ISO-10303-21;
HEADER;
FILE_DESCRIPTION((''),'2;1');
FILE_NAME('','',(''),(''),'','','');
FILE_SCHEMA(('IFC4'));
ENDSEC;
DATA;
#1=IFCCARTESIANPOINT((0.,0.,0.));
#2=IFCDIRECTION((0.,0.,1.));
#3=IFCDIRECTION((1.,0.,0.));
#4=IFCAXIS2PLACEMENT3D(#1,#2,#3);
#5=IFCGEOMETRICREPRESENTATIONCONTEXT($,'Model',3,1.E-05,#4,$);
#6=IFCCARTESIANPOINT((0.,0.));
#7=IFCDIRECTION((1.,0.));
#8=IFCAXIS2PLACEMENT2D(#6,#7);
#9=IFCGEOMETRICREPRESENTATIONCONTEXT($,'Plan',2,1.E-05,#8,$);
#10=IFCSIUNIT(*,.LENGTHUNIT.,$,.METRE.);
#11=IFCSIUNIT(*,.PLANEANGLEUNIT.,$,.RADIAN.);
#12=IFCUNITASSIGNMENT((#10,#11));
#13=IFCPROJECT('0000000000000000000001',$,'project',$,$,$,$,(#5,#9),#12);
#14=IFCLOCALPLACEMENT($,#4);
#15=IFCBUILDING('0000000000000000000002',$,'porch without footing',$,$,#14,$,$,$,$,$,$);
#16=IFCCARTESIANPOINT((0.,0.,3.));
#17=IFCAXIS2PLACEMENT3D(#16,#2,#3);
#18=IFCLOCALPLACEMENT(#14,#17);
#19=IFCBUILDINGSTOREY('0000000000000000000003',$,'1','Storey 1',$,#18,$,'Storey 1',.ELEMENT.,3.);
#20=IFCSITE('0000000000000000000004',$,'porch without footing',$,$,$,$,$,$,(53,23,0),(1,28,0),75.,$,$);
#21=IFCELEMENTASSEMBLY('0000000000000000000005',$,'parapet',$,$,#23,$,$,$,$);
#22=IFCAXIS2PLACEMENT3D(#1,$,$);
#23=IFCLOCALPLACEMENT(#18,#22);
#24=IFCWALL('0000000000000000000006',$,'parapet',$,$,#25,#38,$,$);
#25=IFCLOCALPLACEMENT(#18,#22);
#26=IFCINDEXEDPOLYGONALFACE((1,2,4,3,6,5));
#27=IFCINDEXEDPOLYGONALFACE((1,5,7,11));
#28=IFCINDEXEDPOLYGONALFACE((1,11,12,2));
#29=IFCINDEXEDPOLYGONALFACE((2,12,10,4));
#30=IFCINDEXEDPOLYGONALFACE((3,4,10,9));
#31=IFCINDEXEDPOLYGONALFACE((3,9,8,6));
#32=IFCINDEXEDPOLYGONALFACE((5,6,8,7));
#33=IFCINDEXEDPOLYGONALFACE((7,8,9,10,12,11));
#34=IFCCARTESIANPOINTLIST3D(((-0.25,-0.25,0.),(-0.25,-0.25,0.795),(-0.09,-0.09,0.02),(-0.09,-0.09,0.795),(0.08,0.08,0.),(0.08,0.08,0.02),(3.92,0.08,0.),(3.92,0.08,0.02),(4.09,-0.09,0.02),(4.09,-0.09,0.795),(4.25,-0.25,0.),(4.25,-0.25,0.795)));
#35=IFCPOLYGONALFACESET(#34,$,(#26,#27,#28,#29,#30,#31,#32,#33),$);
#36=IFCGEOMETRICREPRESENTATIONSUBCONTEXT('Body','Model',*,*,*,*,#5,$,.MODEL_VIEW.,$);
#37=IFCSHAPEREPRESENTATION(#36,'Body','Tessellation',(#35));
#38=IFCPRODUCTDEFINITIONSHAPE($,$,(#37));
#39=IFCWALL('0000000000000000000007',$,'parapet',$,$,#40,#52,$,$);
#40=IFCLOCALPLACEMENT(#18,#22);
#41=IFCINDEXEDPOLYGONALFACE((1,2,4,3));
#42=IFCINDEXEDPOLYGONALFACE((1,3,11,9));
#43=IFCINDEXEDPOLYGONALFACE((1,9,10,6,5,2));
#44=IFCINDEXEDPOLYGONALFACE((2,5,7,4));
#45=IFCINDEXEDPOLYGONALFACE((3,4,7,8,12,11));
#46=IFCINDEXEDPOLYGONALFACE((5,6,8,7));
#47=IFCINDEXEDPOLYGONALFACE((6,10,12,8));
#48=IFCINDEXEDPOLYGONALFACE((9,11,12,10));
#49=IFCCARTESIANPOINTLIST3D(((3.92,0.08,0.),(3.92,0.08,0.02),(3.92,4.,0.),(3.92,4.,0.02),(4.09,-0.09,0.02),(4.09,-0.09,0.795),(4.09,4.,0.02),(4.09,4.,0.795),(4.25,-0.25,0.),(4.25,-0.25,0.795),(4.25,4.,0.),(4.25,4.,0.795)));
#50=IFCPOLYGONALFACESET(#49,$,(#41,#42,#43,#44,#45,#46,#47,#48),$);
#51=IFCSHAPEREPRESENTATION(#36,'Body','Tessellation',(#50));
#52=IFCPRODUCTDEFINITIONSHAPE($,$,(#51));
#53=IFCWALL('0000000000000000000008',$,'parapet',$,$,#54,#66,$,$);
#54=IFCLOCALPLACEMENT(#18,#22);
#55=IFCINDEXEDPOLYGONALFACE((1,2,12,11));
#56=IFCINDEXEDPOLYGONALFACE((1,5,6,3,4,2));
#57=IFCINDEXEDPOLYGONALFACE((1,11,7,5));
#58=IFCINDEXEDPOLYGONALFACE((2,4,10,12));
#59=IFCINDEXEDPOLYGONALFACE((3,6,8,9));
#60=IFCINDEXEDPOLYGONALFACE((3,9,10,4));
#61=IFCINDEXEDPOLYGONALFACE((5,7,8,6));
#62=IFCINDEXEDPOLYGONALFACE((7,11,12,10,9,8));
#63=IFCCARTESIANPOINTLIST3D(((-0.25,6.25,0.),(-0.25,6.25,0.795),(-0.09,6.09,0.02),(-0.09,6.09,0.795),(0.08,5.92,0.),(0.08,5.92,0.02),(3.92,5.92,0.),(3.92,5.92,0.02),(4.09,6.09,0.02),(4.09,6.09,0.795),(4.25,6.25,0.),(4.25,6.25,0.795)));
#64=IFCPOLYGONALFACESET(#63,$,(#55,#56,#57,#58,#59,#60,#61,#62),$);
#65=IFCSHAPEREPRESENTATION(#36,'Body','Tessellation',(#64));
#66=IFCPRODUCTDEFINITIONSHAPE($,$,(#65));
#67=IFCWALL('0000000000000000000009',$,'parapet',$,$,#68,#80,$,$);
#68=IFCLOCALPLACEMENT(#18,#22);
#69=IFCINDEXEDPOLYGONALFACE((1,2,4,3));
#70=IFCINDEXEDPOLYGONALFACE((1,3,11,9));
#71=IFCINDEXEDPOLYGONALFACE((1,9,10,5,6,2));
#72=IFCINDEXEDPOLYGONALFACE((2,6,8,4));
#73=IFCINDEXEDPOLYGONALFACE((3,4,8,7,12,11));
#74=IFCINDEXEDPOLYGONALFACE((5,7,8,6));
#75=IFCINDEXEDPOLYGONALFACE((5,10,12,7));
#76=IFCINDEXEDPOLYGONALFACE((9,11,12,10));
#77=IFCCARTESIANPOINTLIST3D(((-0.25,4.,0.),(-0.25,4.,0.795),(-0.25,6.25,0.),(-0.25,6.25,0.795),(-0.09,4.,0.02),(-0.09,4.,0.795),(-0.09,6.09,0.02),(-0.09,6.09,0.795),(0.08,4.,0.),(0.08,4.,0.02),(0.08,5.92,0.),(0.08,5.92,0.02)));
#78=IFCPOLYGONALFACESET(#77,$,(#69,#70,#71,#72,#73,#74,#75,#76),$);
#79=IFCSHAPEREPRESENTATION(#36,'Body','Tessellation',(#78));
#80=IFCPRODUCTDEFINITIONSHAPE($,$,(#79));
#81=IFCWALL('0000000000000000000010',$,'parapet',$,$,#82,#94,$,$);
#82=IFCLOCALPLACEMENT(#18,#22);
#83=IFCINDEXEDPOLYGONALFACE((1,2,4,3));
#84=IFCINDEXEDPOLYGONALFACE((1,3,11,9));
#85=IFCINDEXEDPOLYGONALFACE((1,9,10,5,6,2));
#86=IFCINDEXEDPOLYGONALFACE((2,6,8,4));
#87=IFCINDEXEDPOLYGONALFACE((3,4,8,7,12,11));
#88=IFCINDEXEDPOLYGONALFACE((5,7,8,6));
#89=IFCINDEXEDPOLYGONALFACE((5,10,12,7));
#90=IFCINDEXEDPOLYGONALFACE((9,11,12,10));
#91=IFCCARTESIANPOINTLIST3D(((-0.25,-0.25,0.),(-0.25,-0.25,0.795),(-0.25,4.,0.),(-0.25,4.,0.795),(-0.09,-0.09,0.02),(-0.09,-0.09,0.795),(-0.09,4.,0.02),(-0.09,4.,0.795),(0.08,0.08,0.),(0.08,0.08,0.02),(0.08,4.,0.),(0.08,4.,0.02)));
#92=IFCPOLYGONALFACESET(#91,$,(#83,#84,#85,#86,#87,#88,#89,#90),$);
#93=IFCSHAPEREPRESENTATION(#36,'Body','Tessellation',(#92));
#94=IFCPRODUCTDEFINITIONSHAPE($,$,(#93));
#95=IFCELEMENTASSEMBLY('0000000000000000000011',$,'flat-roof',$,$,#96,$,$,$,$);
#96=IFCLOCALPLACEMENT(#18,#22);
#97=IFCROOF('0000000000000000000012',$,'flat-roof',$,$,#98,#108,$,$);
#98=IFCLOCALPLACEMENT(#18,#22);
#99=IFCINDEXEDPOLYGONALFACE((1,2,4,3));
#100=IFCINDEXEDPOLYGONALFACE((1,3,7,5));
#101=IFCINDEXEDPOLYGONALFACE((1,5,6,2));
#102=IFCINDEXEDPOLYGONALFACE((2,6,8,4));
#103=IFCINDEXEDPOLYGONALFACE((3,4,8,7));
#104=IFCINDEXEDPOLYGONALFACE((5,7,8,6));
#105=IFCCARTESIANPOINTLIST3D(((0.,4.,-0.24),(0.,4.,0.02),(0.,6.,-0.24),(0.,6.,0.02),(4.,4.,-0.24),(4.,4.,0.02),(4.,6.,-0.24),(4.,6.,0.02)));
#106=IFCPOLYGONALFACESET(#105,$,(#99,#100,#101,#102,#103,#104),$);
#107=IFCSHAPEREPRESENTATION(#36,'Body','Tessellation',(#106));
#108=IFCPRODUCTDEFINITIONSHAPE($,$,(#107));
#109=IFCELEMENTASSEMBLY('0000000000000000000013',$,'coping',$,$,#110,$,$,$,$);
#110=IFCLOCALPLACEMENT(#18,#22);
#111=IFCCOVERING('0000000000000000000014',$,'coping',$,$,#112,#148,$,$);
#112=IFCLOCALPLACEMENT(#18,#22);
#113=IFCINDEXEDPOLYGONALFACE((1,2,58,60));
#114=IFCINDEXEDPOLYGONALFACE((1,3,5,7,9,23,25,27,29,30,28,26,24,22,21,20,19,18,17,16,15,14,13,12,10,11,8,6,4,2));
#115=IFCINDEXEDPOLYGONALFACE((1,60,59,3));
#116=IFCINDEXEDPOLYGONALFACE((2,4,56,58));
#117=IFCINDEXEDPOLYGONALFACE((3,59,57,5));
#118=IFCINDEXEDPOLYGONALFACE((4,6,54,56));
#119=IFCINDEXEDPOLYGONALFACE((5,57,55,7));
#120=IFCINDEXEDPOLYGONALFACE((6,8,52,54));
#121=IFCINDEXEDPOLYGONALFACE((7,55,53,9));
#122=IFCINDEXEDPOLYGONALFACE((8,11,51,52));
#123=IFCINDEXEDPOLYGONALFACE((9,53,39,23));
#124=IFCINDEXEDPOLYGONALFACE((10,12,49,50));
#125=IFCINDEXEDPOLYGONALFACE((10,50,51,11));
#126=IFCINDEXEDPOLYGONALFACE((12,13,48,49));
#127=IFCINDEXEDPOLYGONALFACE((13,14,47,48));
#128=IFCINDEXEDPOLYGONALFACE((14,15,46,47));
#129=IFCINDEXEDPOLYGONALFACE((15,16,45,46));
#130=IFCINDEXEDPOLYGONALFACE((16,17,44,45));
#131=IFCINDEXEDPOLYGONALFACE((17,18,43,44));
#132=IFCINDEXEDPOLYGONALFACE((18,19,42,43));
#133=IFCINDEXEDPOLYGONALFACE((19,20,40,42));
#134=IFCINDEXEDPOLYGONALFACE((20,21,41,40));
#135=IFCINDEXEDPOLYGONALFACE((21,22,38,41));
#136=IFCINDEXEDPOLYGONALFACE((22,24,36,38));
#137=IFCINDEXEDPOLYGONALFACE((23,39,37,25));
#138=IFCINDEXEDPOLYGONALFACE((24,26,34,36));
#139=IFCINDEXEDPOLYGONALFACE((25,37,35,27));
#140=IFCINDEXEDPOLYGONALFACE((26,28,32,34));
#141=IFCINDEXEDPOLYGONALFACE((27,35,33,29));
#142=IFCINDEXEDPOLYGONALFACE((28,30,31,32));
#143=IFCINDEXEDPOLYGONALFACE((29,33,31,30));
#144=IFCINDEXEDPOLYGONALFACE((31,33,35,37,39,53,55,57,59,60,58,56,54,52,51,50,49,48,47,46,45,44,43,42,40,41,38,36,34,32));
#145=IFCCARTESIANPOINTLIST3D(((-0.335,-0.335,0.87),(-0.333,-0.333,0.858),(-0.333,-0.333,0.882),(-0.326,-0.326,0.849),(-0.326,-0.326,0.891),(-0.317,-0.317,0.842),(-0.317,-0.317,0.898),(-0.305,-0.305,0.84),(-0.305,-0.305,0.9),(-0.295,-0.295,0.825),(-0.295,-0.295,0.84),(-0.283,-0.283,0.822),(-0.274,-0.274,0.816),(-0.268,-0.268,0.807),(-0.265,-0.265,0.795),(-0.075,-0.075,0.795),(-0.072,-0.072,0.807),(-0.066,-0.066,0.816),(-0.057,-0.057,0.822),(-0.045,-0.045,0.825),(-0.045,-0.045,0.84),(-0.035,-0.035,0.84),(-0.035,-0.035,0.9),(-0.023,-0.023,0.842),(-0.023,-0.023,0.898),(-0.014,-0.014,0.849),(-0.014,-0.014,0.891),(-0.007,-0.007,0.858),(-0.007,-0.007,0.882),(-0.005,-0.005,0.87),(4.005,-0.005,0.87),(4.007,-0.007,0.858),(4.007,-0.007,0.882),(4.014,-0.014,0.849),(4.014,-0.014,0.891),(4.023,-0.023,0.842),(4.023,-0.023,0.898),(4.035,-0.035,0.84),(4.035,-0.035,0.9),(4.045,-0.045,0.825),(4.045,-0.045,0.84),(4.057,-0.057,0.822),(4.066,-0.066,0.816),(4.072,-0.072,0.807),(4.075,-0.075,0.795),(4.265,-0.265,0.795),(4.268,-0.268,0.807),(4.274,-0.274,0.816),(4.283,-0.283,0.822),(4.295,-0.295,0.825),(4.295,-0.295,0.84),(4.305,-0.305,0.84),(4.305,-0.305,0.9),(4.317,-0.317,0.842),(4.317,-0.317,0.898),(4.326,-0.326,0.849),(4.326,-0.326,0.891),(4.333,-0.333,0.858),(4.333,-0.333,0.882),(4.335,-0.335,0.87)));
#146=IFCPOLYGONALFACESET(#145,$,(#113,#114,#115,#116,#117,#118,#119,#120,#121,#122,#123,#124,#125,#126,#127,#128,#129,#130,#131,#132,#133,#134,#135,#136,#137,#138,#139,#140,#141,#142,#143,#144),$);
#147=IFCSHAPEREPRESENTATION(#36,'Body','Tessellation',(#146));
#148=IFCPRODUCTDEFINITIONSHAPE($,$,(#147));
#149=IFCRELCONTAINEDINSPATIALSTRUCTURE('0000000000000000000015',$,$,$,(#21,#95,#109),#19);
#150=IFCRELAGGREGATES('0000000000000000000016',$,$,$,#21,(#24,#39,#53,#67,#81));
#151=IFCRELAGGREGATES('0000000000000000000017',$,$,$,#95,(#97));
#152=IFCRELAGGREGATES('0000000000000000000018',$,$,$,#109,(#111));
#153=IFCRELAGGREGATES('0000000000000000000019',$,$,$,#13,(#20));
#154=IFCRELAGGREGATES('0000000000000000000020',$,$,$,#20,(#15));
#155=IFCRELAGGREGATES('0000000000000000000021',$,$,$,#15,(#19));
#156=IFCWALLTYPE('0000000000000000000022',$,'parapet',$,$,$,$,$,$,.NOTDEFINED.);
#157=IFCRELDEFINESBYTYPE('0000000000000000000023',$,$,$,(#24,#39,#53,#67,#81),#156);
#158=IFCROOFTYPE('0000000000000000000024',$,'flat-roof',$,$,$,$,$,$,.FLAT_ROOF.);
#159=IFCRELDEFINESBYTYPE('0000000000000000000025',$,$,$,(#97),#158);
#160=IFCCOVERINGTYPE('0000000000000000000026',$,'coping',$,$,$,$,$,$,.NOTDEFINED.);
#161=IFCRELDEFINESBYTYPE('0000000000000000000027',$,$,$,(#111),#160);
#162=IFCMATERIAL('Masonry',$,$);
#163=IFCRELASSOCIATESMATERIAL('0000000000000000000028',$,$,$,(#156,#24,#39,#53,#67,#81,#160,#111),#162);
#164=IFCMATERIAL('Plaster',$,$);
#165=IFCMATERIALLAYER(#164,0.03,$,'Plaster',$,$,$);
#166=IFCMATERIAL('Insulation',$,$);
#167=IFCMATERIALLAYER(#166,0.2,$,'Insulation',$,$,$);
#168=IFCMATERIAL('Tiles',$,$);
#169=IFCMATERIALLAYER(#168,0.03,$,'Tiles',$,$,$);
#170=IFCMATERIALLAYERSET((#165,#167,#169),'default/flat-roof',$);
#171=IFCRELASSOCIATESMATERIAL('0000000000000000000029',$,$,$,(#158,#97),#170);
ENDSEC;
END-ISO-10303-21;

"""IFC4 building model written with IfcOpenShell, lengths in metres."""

from ifc_helpers import new_model, si_unit, frame, origin, origin_with_axes, origin_2d_with_axis, place, context, subcontext, project, spatial, polyline, outline, extrude, clip, halfspace, material, layer, layer_set, layer_usage, material_profile, profile_set, profile_usage, type_object, element, aggregate, save


model = new_model("IFC4")

# Units and contexts
model_context = context("Model", 3, precision=1e-05, world=origin_with_axes())
plan_context = context("Plan", 2, precision=1e-05, world=origin_2d_with_axis())
body_context = subcontext(model_context, "Body", "Model", "MODEL_VIEW")
ifc_project = project(units=[si_unit("LENGTHUNIT", "METRE"), si_unit("PLANEANGLEUNIT", "RADIAN")], contexts=[model_context, plan_context])

# Site, building, storey
site = spatial("IfcSite", under=ifc_project, Name="porch without footing", RefLatitude=(53, 23, 0), RefLongitude=(1, 28, 0), RefElevation=75.0)
building_placement = place(None, origin_with_axes())
building = spatial("IfcBuilding", under=site, at=building_placement, Name="porch without footing")
storey_placement = place(building_placement, frame((0.0, 0.0, 3.0), z_axis=(0.0, 0.0, 1.0), x_axis=(1.0, 0.0, 0.0)))
storey = spatial("IfcBuildingStorey", under=building, at=storey_placement, Name="1", Description="Storey 1", LongName="Storey 1", CompositionType="ELEMENT", Elevation=3.0)

# Element assembly, walls
assembly_1_placement = place(storey_placement, frame((0.0, 0.0, -3.0), z_axis=(0.0, 0.0, 1.0), x_axis=(1.0, 0.0, 0.0)))
assembly_1 = element("IfcElementAssembly", 1, at=assembly_1_placement, inside=storey, Name="parapet")
ifc_material_1 = material(Name="Masonry")
ifc_material_profile_1 = material_profile(ifc_material_1, outline(polyline([(0.25, 0.0), (0.25, 0.795), (0.09, 0.795), (0.09, 0.02), (-0.08, 0.02), (-0.08, 0.0), (0.25, 0.0)])))
ifc_profile_set_1 = profile_set([ifc_material_profile_1])
ifc_profile_usage_1 = profile_usage(ifc_profile_set_1)
wall_type = type_object("IfcWallType", Name="parapet", PredefinedType="NOTDEFINED", material=ifc_profile_set_1)
wall_1_placement = place(assembly_1_placement, frame((5.0, 0.0, 3.0), z_axis=(-1.0, 0.0, 0.0), x_axis=(0.0, -1.0, 0.0)))
wall_1 = element("IfcWall", 2, at=wall_1_placement, type_object=wall_type, material=ifc_profile_usage_1, Name="parapet", context=body_context, shape_type="Clipping", body=[
    clip(clip(extrude(outline(polyline([(0.25, 0.0), (0.25, 0.795), (0.09, 0.795), (0.09, 0.02), (-0.08, 0.02), (-0.08, 0.0), (0.25, 0.0)])), origin_with_axes(), (0.0, 0.0, 1.0), 6.0), halfspace(frame((0.0, -3.0, 1.0), z_axis=(-0.707107, 0.0, -0.707107), x_axis=(0.0, 1.0, 0.0)), False)), halfspace(frame((0.0, -3.0, 5.0), z_axis=(-0.707107, 0.0, 0.707107), x_axis=(0.0, 1.0, 0.0)), False)),
])
ifc_profile_usage_2 = profile_usage(ifc_profile_set_1)
wall_2_placement = place(assembly_1_placement, frame((4.0, 5.0, 3.0), z_axis=(0.0, -1.0, 0.0), x_axis=(1.0, 0.0, 0.0)))
wall_2 = element("IfcWall", 3, at=wall_2_placement, type_object=wall_type, material=ifc_profile_usage_2, Name="parapet", context=body_context, shape_type="Clipping", body=[
    clip(clip(extrude(outline(polyline([(0.25, 0.0), (0.25, 0.795), (0.09, 0.795), (0.09, 0.02), (-0.08, 0.02), (-0.08, 0.0), (0.25, 0.0)])), origin_with_axes(), (0.0, 0.0, 1.0), 6.0), halfspace(frame((0.0, -3.0, 1.0), z_axis=(0.0, 0.0, -1.0), x_axis=(1.0, 0.0, 0.0)), False)), halfspace(frame((0.0, -3.0, 5.0), z_axis=(-0.707107, 0.0, 0.707107), x_axis=(0.0, 1.0, 0.0)), False)),
])
ifc_profile_usage_3 = profile_usage(ifc_profile_set_1)
wall_3_placement = place(assembly_1_placement, frame((-1.0, 6.0, 3.0), z_axis=(1.0, 0.0, 0.0), x_axis=(0.0, 1.0, 0.0)))
wall_3 = element("IfcWall", 4, at=wall_3_placement, type_object=wall_type, material=ifc_profile_usage_3, Name="parapet", context=body_context, shape_type="Clipping", body=[
    clip(clip(extrude(outline(polyline([(0.25, 0.0), (0.25, 0.795), (0.09, 0.795), (0.09, 0.02), (-0.08, 0.02), (-0.08, 0.0), (0.25, 0.0)])), origin_with_axes(), (0.0, 0.0, 1.0), 6.0), halfspace(frame((0.0, -3.0, 1.0), z_axis=(-0.707107, 0.0, -0.707107), x_axis=(0.0, 1.0, 0.0)), False)), halfspace(frame((0.0, -3.0, 5.0), z_axis=(-0.707107, 0.0, 0.707107), x_axis=(0.0, 1.0, 0.0)), False)),
])
ifc_profile_usage_4 = profile_usage(ifc_profile_set_1)
wall_4_placement = place(assembly_1_placement, frame((0.0, 3.0, 3.0), z_axis=(0.0, 1.0, 0.0), x_axis=(-1.0, 0.0, 0.0)))
wall_4 = element("IfcWall", 5, at=wall_4_placement, type_object=wall_type, material=ifc_profile_usage_4, Name="parapet", context=body_context, shape_type="Clipping", body=[
    clip(clip(extrude(outline(polyline([(0.25, 0.0), (0.25, 0.795), (0.09, 0.795), (0.09, 0.02), (-0.08, 0.02), (-0.08, 0.0), (0.25, 0.0)])), origin_with_axes(), (0.0, 0.0, 1.0), 4.0), halfspace(frame((0.0, -3.0, 1.0), z_axis=(0.0, 0.0, -1.0), x_axis=(1.0, 0.0, 0.0)), False)), halfspace(frame((0.0, -3.0, 3.0), z_axis=(-0.707107, 0.0, 0.707107), x_axis=(0.0, 1.0, 0.0)), False)),
])
ifc_profile_usage_5 = profile_usage(ifc_profile_set_1)
wall_5_placement = place(assembly_1_placement, frame((0.0, -1.0, 3.0), z_axis=(0.0, 1.0, 0.0), x_axis=(-1.0, 0.0, 0.0)))
wall_5 = element("IfcWall", 6, at=wall_5_placement, type_object=wall_type, material=ifc_profile_usage_5, Name="parapet", context=body_context, shape_type="Clipping", body=[
    clip(clip(extrude(outline(polyline([(0.25, 0.0), (0.25, 0.795), (0.09, 0.795), (0.09, 0.02), (-0.08, 0.02), (-0.08, 0.0), (0.25, 0.0)])), origin_with_axes(), (0.0, 0.0, 1.0), 6.0), halfspace(frame((0.0, -3.0, 1.0), z_axis=(-0.707107, 0.0, -0.707107), x_axis=(0.0, 1.0, 0.0)), False)), halfspace(frame((0.0, -3.0, 5.0), z_axis=(0.0, 0.0, 1.0), x_axis=(-1.0, 0.0, 0.0)), False)),
])
aggregate(assembly_1, [wall_1, wall_2, wall_3, wall_4, wall_5])

# Element assembly, roof
assembly_2_placement = place(storey_placement, frame((0.0, 0.0, -3.0), z_axis=(0.0, 0.0, 1.0), x_axis=(1.0, 0.0, 0.0)))
assembly_2 = element("IfcElementAssembly", 7, at=assembly_2_placement, inside=storey, Name="flat-roof")
ifc_material_2 = material(Name="Plaster")
ifc_layer_1 = layer(ifc_material_2, 0.03, Name="Plaster")
ifc_material_3 = material(Name="Insulation")
ifc_layer_2 = layer(ifc_material_3, 0.2, Name="Insulation")
ifc_material_4 = material(Name="Tiles")
ifc_layer_3 = layer(ifc_material_4, 0.03, Name="Tiles")
ifc_layer_set = layer_set([ifc_layer_1, ifc_layer_2, ifc_layer_3], Name="default/flat-roof")
roof_type = type_object("IfcRoofType", Name="flat-roof", PredefinedType="FLAT_ROOF", material=ifc_layer_set)
ifc_layer_usage_1 = layer_usage(ifc_layer_set, "AXIS3", "POSITIVE", 0.0)
roof_1_placement = place(assembly_2_placement, frame((4.0, 4.0, 2.76), z_axis=(0.0, 0.0, 1.0), x_axis=(1.0, 0.0, 0.0)))
roof_1 = element("IfcRoof", 8, at=roof_1_placement, type_object=roof_type, material=ifc_layer_usage_1, Name="flat-roof", context=body_context, shape_type="SweptSolid", body=[
    extrude(outline(polyline([(0.0, 0.0), (0.0, 2.0), (-4.0, 2.0), (-4.0, 0.0), (0.0, 0.0)])), origin(), (0.0, 0.0, 1.0), 0.26),
])
aggregate(assembly_2, [roof_1])

# Element assembly, covering
assembly_3_placement = place(storey_placement, frame((0.0, 0.0, -3.0), z_axis=(0.0, 0.0, 1.0), x_axis=(1.0, 0.0, 0.0)))
assembly_3 = element("IfcElementAssembly", 9, at=assembly_3_placement, inside=storey, Name="coping")
ifc_material_profile_2 = material_profile(ifc_material_1, outline(polyline([(0.265, 0.795), (0.268, 0.807), (0.274, 0.816), (0.283, 0.822), (0.295, 0.825), (0.295, 0.84), (0.305, 0.84), (0.317, 0.842), (0.326, 0.849), (0.333, 0.858), (0.335, 0.87), (0.333, 0.882), (0.326, 0.891), (0.317, 0.898), (0.305, 0.9), (0.035, 0.9), (0.023, 0.898), (0.014, 0.891), (0.007, 0.882), (0.005, 0.87), (0.007, 0.858), (0.014, 0.849), (0.023, 0.842), (0.035, 0.84), (0.045, 0.84), (0.045, 0.825), (0.057, 0.822), (0.066, 0.816), (0.072, 0.807), (0.075, 0.795), (0.265, 0.795)])))
ifc_profile_set_2 = profile_set([ifc_material_profile_2])
ifc_profile_usage_6 = profile_usage(ifc_profile_set_2)
covering_type_1 = type_object("IfcCoveringType", Name="coping", PredefinedType="NOTDEFINED", material=ifc_profile_set_2)
covering_1_placement = place(assembly_3_placement, frame((5.0, 0.0, 3.0), z_axis=(-1.0, 0.0, 0.0), x_axis=(0.0, -1.0, 0.0)))
covering_1 = element("IfcCovering", 10, at=covering_1_placement, type_object=covering_type_1, material=ifc_profile_usage_6, Name="coping", context=body_context, shape_type="Clipping", body=[
    clip(clip(extrude(outline(polyline([(0.265, 0.795), (0.268, 0.807), (0.274, 0.816), (0.283, 0.822), (0.295, 0.825), (0.295, 0.84), (0.305, 0.84), (0.317, 0.842), (0.326, 0.849), (0.333, 0.858), (0.335, 0.87), (0.333, 0.882), (0.326, 0.891), (0.317, 0.898), (0.305, 0.9), (0.035, 0.9), (0.023, 0.898), (0.014, 0.891), (0.007, 0.882), (0.005, 0.87), (0.007, 0.858), (0.014, 0.849), (0.023, 0.842), (0.035, 0.84), (0.045, 0.84), (0.045, 0.825), (0.057, 0.822), (0.066, 0.816), (0.072, 0.807), (0.075, 0.795), (0.265, 0.795)])), origin_with_axes(), (0.0, 0.0, 1.0), 6.0), halfspace(frame((0.0, -3.0, 1.0), z_axis=(-0.707107, 0.0, -0.707107), x_axis=(0.0, 1.0, 0.0)), False)), halfspace(frame((0.0, -3.0, 5.0), z_axis=(-0.707107, 0.0, 0.707107), x_axis=(0.0, 1.0, 0.0)), False)),
])
aggregate(assembly_3, [covering_1])

save(model, "model.ifc")
